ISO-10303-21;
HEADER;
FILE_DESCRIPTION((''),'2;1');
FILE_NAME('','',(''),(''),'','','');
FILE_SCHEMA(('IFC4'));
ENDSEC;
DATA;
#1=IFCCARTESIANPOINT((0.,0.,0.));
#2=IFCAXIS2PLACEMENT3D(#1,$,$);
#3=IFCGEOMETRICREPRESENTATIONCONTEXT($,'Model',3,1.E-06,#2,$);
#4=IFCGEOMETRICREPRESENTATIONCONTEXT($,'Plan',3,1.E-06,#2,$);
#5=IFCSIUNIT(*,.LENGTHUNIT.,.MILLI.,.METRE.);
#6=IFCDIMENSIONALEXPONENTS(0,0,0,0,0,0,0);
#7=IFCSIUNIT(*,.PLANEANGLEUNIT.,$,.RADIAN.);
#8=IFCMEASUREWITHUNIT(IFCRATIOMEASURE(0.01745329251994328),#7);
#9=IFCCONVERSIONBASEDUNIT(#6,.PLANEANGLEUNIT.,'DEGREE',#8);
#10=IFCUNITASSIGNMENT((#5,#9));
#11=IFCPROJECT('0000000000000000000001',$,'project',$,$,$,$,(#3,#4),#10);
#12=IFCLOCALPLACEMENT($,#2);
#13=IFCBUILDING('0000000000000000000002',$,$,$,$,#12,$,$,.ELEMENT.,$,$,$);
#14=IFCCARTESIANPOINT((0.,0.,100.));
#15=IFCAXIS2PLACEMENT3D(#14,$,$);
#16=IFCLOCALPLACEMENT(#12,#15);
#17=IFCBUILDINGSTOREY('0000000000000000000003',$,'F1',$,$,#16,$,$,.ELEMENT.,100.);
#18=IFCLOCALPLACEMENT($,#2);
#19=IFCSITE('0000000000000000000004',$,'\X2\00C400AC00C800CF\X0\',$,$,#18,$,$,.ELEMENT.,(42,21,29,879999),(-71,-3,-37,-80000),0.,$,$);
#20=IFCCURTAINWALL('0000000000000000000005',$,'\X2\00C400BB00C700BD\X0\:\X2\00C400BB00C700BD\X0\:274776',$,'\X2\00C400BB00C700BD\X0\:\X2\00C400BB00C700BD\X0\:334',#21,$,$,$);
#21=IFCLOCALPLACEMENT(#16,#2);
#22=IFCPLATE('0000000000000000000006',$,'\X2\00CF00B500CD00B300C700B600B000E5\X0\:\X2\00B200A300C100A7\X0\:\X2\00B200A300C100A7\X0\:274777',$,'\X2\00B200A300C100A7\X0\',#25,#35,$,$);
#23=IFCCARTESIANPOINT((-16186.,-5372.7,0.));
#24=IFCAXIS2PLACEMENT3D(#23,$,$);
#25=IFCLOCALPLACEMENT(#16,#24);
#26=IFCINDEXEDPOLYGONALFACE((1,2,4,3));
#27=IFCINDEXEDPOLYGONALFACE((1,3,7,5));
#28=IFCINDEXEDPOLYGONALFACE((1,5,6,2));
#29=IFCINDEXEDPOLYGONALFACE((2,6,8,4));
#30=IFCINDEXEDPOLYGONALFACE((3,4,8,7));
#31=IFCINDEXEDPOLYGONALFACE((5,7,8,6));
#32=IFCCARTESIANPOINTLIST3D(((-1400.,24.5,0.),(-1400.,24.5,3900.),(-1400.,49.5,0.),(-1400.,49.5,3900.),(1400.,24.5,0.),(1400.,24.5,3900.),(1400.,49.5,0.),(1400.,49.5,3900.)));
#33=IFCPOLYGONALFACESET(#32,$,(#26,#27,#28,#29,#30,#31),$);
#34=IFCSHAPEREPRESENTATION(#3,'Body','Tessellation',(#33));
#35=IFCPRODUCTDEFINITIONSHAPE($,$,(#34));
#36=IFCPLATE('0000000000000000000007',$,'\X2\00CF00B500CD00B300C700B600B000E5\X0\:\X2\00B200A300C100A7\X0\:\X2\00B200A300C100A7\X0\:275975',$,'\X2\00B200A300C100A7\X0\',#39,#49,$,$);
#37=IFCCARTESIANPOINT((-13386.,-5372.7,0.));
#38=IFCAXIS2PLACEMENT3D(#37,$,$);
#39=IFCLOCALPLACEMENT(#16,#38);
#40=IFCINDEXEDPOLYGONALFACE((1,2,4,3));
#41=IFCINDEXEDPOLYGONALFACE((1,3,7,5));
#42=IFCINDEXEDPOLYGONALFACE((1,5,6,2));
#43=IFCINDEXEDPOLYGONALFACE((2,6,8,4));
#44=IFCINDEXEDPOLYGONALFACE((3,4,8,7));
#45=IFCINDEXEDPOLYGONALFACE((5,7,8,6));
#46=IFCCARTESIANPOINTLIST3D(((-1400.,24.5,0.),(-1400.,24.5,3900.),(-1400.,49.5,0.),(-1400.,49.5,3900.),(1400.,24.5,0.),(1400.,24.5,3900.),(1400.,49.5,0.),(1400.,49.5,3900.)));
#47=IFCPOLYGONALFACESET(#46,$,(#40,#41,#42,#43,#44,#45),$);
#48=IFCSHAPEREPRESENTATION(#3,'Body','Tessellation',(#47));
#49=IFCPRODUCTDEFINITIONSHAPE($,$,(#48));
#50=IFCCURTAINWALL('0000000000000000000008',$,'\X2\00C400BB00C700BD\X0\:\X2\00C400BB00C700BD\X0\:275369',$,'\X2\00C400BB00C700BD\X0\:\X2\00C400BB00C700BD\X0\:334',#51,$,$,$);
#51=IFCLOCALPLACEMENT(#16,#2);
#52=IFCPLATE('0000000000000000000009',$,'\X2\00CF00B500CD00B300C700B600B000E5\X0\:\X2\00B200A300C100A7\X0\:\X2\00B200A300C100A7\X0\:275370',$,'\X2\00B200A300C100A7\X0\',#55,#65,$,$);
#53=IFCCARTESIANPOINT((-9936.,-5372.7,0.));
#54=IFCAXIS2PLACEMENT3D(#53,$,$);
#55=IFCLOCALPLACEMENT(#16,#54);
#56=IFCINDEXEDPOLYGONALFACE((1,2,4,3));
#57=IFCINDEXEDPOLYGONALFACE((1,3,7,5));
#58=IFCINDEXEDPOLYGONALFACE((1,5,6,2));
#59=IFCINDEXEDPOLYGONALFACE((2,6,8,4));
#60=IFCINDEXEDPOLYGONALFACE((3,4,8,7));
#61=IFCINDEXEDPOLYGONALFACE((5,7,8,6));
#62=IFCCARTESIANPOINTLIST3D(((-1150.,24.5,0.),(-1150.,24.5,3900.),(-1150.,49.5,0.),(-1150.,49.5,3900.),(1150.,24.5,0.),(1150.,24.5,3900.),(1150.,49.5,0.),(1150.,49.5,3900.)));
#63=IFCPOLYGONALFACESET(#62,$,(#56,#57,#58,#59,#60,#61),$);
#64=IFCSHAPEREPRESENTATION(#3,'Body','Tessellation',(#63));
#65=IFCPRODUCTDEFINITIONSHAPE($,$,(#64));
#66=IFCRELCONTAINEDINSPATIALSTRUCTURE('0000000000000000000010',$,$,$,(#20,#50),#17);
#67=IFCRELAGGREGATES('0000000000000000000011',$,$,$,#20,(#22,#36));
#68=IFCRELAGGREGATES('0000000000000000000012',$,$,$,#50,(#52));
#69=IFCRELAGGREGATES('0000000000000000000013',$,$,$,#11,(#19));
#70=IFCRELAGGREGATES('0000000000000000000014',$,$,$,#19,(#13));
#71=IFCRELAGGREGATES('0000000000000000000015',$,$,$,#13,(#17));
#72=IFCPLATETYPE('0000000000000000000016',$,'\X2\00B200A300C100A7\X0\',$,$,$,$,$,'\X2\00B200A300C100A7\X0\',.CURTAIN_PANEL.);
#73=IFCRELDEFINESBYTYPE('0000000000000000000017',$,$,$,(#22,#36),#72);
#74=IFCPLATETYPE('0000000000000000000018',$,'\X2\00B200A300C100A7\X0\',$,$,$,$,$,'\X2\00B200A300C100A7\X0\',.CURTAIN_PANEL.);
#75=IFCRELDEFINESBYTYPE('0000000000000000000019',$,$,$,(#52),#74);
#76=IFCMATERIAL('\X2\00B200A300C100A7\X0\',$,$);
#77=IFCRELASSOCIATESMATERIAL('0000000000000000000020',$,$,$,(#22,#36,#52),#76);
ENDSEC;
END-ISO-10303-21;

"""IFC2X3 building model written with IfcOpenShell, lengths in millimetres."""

from ifc_helpers import new_model, entity, si_unit, converted_unit, frame, origin, origin_2d_with_axis, place, context, project, spatial, rectangle, extrude, source, transform, mapped, material, type_object, type_shapes, element, aggregate, save


model = new_model("IFC2X3")

# Units and contexts
model_context = context("Model", 3, precision=1e-06, world=origin())
plan_context = context("Plan", 3, precision=1e-06, world=origin())
ifc_project = project(units=[si_unit("LENGTHUNIT", "METRE", prefix="MILLI"), converted_unit("PLANEANGLEUNIT", "DEGREE", entity("IfcRatioMeasure", 0.01745329251994328), si_unit("PLANEANGLEUNIT", "RADIAN"), dimensions=[0, 0, 0, 0, 0, 0, 0])], contexts=[model_context, plan_context])

# Site, building, storey
site_placement = place(None, origin())
site = spatial("IfcSite", under=ifc_project, at=site_placement, Name="Ä¬ÈÏ", CompositionType="ELEMENT", RefLatitude=(42, 21, 29, 879999), RefLongitude=(-71, -3, -37, -80000), RefElevation=0.0)
building_placement = place(None, origin())
building = spatial("IfcBuilding", under=site, at=building_placement, CompositionType="ELEMENT")
storey_placement = place(building_placement, frame((0.0, 0.0, 100.0)))
storey = spatial("IfcBuildingStorey", under=building, at=storey_placement, Name="F1", CompositionType="ELEMENT", Elevation=100.0)

# Curtain wall
curtain_wall_1_placement = place(storey_placement, origin())
curtain_wall_1 = element("IfcCurtainWall", 1, at=curtain_wall_1_placement, inside=storey, Name="Ä»Ç½:Ä»Ç½:274776", ObjectType="Ä»Ç½:Ä»Ç½:334")

# Plates
ifc_material_1 = material(Name="²£Á§")
plate_type_1 = type_object("IfcPlateType", Name="²£Á§", ElementType="²£Á§", PredefinedType="CURTAIN_PANEL")
shared_shape_1 = source(origin(), model_context, "Body", "SweptSolid", [
    extrude(rectangle(XDim=25.0, YDim=2800.0, at=origin_2d_with_axis()), frame((0.0, 37.0, 0.0), z_axis=(0.0, 0.0, 1.0), x_axis=(0.0, 1.0, 0.0)), (0.0, 0.0, 1.0), 3900.0),
])
type_shapes(plate_type_1, [shared_shape_1])
plate_1_placement = place(storey_placement, frame((-16186.0, -5372.7, 0.0)))
plate_1 = element("IfcPlate", 2, at=plate_1_placement, type_object=plate_type_1, material=ifc_material_1, Name="ÏµÍ³Ç¶°å:²£Á§:²£Á§:274777", ObjectType="²£Á§", context=model_context, shape_type="MappedRepresentation", body=[
    mapped(shared_shape_1, transform((0.0, 0.0, 0.0), scale=1.0)),
])
plate_2_placement = place(storey_placement, frame((-13386.0, -5372.7, 0.0)))
plate_2 = element("IfcPlate", 3, at=plate_2_placement, type_object=plate_type_1, material=ifc_material_1, Name="ÏµÍ³Ç¶°å:²£Á§:²£Á§:275975", ObjectType="²£Á§", context=model_context, shape_type="MappedRepresentation", body=[
    mapped(shared_shape_1, transform((0.0, 0.0, 0.0), scale=1.0)),
])
aggregate(curtain_wall_1, [plate_1, plate_2])

# Curtain wall, plate
curtain_wall_2_placement = place(storey_placement, origin())
curtain_wall_2 = element("IfcCurtainWall", 4, at=curtain_wall_2_placement, inside=storey, Name="Ä»Ç½:Ä»Ç½:275369", ObjectType="Ä»Ç½:Ä»Ç½:334")
plate_type_2 = type_object("IfcPlateType", Name="²£Á§", ElementType="²£Á§", PredefinedType="CURTAIN_PANEL")
shared_shape_2 = source(origin(), model_context, "Body", "SweptSolid", [
    extrude(rectangle(XDim=25.0, YDim=2300.0, at=origin_2d_with_axis()), frame((0.0, 37.0, 0.0), z_axis=(0.0, 0.0, 1.0), x_axis=(0.0, 1.0, 0.0)), (0.0, 0.0, 1.0), 3900.0),
])
type_shapes(plate_type_2, [shared_shape_2])
plate_3_placement = place(storey_placement, frame((-9936.0, -5372.7, 0.0)))
plate_3 = element("IfcPlate", 5, at=plate_3_placement, type_object=plate_type_2, material=ifc_material_1, Name="ÏµÍ³Ç¶°å:²£Á§:²£Á§:275370", ObjectType="²£Á§", context=model_context, shape_type="MappedRepresentation", body=[
    mapped(shared_shape_2, transform((0.0, 0.0, 0.0), scale=1.0)),
])
aggregate(curtain_wall_2, [plate_3])

save(model, "model.ifc")
